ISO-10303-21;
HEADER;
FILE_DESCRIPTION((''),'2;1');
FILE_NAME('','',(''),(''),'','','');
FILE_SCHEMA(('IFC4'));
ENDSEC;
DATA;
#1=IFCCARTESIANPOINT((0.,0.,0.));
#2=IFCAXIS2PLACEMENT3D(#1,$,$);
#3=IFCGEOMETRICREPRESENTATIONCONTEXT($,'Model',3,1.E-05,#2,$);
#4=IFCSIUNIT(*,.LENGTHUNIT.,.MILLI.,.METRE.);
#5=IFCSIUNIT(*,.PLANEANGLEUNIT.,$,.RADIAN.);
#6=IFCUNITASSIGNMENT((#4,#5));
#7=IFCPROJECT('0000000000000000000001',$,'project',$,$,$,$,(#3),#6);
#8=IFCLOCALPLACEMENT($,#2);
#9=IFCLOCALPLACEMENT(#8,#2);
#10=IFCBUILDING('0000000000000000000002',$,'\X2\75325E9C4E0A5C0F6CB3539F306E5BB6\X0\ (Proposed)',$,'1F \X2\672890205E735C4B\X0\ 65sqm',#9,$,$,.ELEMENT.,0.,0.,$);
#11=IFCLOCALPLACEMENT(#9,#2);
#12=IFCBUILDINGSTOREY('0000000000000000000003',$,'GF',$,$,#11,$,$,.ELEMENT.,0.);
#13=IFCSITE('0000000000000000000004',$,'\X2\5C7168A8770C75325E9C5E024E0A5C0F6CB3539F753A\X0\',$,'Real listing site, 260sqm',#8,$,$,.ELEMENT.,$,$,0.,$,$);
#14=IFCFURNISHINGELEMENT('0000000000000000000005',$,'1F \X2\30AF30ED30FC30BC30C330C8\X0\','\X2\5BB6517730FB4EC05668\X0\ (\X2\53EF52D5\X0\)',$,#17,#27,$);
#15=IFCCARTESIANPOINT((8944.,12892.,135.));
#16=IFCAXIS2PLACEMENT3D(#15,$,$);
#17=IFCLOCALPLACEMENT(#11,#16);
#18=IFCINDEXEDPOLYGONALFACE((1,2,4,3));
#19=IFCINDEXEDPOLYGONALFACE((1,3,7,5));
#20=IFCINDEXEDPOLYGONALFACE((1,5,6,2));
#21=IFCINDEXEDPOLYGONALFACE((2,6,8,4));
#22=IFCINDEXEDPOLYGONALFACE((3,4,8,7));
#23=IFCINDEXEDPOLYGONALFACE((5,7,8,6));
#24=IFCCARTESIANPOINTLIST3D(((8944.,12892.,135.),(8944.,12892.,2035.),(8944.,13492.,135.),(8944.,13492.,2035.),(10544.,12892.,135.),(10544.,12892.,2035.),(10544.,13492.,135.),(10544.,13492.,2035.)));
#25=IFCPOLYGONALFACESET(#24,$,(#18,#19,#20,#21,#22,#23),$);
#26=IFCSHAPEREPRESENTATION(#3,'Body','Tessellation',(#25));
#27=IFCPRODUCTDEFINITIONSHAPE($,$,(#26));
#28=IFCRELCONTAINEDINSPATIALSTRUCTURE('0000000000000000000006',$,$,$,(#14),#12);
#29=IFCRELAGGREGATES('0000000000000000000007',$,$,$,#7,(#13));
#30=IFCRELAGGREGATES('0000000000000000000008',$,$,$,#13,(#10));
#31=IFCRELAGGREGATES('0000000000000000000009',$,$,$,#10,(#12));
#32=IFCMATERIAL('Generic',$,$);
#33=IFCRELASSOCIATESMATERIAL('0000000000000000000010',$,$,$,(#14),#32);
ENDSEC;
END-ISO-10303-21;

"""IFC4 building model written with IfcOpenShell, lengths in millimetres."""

from ifc_helpers import new_model, si_unit, frame, frame_2d, origin, place, context, project, spatial, rectangle, extrude, material, element, save


model = new_model("IFC4")

# Units and contexts
model_context = context("Model", 3, precision=1e-05, world=origin())
ifc_project = project(units=[si_unit("LENGTHUNIT", "METRE", prefix="MILLI"), si_unit("PLANEANGLEUNIT", "RADIAN")], contexts=[model_context])

# Site, building, storey
site_placement = place(None, origin())
site = spatial("IfcSite", under=ifc_project, at=site_placement, Name="山梨県甲府市上小河原町", ObjectType="Real listing site, 260sqm", CompositionType="ELEMENT", RefElevation=0.0)
building_placement = place(site_placement, origin())
building = spatial("IfcBuilding", under=site, at=building_placement, Name="甲府上小河原の家 (Proposed)", ObjectType="1F 木造平屋 65sqm", CompositionType="ELEMENT", ElevationOfRefHeight=0.0, ElevationOfTerrain=0.0)
storey_placement = place(building_placement, origin())
storey = spatial("IfcBuildingStorey", under=building, at=storey_placement, Name="GF", CompositionType="ELEMENT", Elevation=0.0)

# Shared definitions
ifc_material_1 = material(Name="Generic")

# Furnishing element
furnishing_placement = place(storey_placement, frame((8944.0, 12892.0, 135.0)))
element("IfcFurnishingElement", 1, at=furnishing_placement, inside=storey, material=ifc_material_1, Name="1F クローゼット", Description="家具・什器 (可動)", context=model_context, shape_type="SweptSolid", body=[
    extrude(rectangle(XDim=1600.0, YDim=600.0, at=frame_2d((800.0, 300.0))), frame((8944.0, 12892.0, 135.0)), (0.0, 0.0, 1.0), 1900.0),
])

save(model, "model.ifc")
